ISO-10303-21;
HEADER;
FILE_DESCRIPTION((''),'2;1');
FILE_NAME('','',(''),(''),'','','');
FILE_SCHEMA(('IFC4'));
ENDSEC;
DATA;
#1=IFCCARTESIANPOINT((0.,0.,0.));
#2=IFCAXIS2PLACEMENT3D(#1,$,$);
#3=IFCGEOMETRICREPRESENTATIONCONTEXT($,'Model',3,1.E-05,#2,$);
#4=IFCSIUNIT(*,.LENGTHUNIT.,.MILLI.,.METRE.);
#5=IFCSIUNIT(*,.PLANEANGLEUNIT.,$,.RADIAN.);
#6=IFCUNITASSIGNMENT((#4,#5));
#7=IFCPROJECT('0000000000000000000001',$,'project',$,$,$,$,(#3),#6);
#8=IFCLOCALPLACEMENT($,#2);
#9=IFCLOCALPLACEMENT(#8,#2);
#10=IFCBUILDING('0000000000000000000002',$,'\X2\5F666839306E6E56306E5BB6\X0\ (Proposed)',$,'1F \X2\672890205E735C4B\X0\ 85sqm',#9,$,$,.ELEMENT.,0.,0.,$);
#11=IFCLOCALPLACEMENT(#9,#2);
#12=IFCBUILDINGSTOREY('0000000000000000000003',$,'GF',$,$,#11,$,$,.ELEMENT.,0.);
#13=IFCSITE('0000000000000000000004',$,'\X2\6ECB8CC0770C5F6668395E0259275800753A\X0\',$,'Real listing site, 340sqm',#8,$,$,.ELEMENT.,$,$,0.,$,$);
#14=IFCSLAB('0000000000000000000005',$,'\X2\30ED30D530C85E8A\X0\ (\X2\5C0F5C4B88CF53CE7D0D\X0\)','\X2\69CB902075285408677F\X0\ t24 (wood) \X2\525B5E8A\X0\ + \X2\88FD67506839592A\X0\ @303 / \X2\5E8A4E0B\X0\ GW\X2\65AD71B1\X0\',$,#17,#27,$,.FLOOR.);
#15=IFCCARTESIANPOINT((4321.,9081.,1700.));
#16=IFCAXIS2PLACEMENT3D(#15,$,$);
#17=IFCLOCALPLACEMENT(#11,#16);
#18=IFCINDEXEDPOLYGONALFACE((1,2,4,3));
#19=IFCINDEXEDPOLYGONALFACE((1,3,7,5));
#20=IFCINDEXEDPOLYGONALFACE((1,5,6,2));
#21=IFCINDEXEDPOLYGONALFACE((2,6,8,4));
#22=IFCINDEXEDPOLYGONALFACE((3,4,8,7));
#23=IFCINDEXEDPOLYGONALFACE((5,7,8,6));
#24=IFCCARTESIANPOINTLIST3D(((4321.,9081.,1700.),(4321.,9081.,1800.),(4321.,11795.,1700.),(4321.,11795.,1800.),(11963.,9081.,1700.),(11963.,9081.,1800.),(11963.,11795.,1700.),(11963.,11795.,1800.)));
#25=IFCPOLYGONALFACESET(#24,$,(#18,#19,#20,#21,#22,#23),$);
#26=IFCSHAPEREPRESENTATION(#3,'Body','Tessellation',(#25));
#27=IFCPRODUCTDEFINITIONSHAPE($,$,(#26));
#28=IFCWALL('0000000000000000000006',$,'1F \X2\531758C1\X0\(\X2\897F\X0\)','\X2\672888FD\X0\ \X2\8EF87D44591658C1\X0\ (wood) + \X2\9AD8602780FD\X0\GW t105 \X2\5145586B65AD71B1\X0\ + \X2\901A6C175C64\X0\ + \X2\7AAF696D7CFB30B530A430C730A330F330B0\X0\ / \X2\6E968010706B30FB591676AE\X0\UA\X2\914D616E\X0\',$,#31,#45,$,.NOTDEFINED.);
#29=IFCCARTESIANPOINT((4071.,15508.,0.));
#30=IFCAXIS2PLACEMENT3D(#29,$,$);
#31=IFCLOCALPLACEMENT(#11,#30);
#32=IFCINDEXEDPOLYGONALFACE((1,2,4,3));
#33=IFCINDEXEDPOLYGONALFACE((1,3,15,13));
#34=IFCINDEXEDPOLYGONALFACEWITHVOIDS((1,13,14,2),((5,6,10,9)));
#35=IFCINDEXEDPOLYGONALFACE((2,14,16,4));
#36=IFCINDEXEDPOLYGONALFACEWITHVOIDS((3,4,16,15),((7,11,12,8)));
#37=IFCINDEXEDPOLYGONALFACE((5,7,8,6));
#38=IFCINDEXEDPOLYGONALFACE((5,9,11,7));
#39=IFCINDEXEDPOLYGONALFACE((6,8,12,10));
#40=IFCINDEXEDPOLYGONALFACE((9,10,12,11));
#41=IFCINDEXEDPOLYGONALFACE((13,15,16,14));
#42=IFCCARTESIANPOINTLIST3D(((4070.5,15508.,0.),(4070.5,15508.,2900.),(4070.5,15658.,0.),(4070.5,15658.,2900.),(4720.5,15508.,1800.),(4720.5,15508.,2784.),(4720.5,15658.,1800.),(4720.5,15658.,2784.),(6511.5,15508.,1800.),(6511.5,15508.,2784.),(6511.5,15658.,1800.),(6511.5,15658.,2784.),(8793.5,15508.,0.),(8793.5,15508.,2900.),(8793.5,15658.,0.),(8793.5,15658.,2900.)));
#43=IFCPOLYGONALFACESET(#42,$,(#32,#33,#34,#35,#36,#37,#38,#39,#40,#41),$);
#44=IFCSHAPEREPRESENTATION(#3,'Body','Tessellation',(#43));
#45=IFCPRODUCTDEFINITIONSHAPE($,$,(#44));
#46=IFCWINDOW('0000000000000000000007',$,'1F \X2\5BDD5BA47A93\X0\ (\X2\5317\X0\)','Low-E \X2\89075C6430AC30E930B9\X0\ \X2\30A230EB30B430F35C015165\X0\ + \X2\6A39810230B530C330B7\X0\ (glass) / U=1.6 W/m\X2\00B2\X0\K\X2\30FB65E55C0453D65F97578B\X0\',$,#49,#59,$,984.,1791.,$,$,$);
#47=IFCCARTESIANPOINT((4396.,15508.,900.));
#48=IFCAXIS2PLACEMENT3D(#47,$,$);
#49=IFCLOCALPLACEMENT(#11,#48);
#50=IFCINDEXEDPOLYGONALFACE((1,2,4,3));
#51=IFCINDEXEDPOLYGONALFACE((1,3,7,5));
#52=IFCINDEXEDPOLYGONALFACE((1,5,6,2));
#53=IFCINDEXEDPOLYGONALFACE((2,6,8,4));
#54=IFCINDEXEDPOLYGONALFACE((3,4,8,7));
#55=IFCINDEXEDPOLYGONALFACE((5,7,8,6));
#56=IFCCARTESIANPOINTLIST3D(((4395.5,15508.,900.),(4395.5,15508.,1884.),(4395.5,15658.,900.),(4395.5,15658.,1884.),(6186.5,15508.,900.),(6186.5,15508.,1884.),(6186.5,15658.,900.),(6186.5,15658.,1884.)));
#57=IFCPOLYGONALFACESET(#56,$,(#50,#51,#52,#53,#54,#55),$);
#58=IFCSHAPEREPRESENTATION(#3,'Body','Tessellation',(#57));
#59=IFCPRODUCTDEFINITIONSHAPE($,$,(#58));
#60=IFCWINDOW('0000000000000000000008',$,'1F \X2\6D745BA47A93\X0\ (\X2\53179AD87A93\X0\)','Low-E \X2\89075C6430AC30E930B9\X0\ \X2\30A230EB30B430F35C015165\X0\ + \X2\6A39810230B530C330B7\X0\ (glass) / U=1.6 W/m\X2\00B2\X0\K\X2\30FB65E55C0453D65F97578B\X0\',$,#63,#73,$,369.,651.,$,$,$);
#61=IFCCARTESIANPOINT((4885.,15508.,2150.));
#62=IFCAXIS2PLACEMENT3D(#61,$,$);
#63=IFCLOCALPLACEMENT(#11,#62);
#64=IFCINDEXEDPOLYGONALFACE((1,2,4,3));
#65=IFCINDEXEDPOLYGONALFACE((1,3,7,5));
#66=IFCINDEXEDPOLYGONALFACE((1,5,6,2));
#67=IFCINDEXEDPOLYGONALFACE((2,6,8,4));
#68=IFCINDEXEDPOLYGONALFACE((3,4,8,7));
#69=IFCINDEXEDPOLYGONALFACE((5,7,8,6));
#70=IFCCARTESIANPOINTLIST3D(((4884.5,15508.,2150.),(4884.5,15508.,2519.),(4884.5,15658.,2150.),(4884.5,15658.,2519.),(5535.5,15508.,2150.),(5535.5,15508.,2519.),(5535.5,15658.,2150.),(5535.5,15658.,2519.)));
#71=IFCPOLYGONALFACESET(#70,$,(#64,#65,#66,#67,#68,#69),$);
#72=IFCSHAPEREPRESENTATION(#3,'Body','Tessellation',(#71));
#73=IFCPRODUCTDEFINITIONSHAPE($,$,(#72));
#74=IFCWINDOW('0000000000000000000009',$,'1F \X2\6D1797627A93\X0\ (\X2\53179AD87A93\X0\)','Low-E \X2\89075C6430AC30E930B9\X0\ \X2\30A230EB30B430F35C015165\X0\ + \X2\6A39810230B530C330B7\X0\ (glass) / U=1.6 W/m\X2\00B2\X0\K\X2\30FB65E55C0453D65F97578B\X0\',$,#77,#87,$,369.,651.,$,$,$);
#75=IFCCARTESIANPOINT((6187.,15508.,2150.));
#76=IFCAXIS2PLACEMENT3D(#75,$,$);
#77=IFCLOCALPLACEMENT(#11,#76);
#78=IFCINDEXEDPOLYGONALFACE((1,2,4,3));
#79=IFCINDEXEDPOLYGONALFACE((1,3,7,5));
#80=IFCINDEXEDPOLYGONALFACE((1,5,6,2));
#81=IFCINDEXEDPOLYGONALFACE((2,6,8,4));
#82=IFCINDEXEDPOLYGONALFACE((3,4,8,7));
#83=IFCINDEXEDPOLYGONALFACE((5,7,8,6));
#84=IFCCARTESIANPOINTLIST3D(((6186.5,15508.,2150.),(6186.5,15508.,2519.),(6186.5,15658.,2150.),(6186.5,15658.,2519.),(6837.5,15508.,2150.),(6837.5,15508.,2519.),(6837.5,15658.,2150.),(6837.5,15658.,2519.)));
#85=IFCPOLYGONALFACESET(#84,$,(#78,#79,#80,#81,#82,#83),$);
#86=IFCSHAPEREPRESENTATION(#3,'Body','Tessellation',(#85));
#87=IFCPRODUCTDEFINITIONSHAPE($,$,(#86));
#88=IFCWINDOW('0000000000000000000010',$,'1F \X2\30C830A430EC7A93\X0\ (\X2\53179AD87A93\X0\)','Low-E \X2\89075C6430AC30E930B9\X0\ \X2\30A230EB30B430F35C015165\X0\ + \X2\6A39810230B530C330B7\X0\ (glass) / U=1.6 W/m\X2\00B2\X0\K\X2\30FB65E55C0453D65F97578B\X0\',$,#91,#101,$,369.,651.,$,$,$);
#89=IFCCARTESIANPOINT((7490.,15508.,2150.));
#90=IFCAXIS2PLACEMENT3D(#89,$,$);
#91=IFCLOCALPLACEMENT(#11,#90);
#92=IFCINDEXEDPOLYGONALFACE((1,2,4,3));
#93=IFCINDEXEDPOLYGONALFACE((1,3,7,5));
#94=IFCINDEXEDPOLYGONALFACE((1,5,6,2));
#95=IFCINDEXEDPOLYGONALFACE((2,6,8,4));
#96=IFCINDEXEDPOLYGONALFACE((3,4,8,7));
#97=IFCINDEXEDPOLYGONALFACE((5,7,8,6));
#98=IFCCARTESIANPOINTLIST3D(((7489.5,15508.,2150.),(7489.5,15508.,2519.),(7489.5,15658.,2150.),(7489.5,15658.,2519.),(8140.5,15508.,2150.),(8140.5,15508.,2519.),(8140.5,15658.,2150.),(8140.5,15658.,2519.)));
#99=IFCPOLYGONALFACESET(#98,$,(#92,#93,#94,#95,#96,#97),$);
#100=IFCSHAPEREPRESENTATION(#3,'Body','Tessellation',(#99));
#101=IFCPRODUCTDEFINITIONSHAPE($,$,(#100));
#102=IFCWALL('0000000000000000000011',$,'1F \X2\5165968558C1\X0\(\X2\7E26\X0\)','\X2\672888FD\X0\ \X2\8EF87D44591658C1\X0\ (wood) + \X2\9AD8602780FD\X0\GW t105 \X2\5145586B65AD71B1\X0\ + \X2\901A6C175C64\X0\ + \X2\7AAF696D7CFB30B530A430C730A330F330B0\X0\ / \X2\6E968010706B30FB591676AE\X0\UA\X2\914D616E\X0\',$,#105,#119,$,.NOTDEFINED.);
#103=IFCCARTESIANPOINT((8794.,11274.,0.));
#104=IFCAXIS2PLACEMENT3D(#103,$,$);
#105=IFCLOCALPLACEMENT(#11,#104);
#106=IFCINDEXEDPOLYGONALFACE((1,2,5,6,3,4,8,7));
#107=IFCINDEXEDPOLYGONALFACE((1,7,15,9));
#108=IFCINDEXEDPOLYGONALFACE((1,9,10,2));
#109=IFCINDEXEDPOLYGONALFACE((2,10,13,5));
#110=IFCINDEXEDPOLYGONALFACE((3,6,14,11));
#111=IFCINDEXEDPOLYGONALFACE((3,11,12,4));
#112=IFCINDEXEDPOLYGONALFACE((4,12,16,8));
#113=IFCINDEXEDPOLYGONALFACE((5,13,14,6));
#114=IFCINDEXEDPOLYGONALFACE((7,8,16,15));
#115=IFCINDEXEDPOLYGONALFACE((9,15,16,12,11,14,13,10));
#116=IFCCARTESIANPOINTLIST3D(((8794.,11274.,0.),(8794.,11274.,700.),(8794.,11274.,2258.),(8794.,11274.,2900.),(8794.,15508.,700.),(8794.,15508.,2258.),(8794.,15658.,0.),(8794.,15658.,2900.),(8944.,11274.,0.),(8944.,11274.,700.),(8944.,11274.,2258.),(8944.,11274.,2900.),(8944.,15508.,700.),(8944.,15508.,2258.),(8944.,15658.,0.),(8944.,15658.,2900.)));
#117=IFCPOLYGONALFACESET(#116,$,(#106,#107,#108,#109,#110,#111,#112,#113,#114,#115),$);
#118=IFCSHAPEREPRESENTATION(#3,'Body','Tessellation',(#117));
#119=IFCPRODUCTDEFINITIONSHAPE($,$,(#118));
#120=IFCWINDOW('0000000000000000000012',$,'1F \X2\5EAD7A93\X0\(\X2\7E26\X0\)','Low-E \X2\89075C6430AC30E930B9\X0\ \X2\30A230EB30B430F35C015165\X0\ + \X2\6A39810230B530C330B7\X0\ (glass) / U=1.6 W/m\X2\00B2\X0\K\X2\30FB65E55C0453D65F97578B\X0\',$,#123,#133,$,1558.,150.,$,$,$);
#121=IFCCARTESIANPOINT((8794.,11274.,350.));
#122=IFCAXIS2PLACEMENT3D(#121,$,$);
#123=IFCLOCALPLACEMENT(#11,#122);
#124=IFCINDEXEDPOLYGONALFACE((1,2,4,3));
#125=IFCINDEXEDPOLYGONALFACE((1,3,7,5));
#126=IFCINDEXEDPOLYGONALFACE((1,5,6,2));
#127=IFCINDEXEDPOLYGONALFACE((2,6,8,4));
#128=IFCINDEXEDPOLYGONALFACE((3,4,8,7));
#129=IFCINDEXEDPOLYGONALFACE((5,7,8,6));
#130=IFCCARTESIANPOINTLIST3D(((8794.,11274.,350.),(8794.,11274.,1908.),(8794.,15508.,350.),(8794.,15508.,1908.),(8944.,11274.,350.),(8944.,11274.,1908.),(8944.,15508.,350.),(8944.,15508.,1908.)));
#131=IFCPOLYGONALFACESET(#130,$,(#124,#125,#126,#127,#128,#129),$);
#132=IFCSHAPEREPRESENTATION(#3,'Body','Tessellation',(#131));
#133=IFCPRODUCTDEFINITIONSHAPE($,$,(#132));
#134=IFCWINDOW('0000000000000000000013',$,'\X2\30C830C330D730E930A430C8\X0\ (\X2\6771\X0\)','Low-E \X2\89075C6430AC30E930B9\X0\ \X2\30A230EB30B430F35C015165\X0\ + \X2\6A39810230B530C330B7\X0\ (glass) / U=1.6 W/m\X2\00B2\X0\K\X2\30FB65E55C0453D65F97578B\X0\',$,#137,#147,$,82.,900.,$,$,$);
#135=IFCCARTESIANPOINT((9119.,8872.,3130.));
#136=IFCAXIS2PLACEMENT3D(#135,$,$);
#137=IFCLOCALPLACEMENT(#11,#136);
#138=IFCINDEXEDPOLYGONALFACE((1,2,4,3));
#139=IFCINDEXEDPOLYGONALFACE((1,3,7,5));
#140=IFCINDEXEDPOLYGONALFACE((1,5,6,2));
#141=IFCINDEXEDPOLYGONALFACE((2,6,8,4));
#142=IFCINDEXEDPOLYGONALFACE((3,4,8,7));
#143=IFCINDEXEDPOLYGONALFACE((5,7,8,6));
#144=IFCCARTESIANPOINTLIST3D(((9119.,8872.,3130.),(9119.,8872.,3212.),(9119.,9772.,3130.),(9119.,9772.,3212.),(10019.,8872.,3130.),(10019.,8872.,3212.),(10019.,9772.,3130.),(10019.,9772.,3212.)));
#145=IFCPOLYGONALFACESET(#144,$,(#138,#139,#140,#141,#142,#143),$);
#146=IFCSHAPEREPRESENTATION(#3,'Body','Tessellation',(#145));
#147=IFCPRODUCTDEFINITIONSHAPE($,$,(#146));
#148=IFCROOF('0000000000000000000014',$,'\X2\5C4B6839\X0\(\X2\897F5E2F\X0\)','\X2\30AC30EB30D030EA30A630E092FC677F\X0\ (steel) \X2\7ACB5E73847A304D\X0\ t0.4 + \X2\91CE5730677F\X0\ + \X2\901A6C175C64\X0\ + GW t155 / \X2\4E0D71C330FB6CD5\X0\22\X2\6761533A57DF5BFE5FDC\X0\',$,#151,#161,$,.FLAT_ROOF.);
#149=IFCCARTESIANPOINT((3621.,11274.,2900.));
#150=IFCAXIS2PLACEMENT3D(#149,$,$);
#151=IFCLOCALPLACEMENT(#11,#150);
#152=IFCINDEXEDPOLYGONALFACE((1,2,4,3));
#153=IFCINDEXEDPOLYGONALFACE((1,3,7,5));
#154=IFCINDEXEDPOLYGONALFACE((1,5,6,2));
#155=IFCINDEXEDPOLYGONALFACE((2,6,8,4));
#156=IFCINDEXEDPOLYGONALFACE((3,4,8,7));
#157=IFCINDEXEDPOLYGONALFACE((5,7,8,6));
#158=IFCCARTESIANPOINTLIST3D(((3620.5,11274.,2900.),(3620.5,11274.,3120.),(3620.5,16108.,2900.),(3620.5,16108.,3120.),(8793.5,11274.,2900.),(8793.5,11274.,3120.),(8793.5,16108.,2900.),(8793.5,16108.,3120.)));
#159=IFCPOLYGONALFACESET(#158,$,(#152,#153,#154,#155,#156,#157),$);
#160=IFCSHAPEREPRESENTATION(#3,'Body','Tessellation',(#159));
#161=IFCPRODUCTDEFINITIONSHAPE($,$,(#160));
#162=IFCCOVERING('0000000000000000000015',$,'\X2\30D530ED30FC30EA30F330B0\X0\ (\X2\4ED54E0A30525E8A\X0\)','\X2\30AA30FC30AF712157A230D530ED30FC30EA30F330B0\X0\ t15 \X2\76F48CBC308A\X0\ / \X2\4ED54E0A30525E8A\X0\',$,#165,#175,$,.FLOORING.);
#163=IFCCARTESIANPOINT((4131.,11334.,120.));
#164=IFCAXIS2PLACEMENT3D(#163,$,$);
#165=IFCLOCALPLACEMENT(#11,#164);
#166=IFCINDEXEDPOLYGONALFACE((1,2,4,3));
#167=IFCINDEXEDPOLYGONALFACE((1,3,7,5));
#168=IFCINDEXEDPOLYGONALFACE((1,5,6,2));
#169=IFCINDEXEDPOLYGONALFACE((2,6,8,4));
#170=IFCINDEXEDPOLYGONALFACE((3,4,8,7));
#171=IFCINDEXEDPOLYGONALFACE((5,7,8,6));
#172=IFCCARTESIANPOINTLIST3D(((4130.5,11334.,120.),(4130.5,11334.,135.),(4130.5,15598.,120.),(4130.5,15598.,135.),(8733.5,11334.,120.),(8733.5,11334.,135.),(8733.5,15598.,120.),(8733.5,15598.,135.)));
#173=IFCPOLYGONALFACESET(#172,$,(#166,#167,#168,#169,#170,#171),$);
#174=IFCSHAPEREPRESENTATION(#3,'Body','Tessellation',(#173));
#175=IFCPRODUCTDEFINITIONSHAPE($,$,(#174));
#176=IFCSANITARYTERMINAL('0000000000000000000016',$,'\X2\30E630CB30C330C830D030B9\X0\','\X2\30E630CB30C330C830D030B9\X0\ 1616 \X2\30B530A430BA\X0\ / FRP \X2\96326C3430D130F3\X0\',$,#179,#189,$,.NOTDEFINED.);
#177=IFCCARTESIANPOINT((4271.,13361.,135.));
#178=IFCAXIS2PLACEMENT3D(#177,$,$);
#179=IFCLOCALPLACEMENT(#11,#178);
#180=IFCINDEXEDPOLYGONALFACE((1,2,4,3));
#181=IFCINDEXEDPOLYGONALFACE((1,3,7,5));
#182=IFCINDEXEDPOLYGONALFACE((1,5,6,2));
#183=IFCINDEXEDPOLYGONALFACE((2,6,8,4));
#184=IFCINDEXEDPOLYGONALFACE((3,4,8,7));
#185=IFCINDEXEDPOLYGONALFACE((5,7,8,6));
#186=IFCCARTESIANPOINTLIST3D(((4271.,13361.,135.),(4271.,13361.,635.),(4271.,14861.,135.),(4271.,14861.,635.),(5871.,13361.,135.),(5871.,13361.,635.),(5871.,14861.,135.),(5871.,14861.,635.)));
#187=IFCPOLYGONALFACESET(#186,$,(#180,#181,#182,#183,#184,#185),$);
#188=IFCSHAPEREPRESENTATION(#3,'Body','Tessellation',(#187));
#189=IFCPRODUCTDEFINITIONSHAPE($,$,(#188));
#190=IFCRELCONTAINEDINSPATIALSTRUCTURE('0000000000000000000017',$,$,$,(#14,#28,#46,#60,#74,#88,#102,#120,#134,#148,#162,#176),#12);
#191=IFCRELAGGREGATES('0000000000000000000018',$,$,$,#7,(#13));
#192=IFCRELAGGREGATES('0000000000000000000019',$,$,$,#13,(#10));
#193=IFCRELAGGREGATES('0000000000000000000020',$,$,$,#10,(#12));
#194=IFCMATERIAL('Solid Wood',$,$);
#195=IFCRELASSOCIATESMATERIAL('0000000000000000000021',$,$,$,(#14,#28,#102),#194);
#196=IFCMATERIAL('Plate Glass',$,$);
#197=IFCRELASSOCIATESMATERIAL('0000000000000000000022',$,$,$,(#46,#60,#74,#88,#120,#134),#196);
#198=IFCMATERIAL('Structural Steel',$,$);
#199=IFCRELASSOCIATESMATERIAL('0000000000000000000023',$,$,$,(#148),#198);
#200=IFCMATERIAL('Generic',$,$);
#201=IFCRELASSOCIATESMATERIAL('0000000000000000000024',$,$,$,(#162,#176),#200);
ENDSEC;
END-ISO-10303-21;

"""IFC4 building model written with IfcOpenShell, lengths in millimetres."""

from ifc_helpers import new_model, si_unit, frame, frame_2d, origin, place, context, project, spatial, rectangle, extrude, material, element, fill, save


model = new_model("IFC4")

# Units and contexts
model_context = context("Model", 3, precision=1e-05, world=origin())
ifc_project = project(units=[si_unit("LENGTHUNIT", "METRE", prefix="MILLI"), si_unit("PLANEANGLEUNIT", "RADIAN")], contexts=[model_context])

# Site, building, storey
site_placement = place(None, origin())
site = spatial("IfcSite", under=ifc_project, at=site_placement, Name="滋賀県彦根市大堀町", ObjectType="Real listing site, 340sqm", CompositionType="ELEMENT", RefElevation=0.0)
building_placement = place(site_placement, origin())
building = spatial("IfcBuilding", under=site, at=building_placement, Name="彦根の湖の家 (Proposed)", ObjectType="1F 木造平屋 85sqm", CompositionType="ELEMENT", ElevationOfRefHeight=0.0, ElevationOfTerrain=0.0)
storey_placement = place(building_placement, origin())
storey = spatial("IfcBuildingStorey", under=building, at=storey_placement, Name="GF", CompositionType="ELEMENT", Elevation=0.0)

# Slab
ifc_material_1 = material(Name="Solid Wood")
slab_1_placement = place(storey_placement, frame((4321.0, 9081.0, 1700.0)))
element("IfcSlab", 1, at=slab_1_placement, inside=storey, material=ifc_material_1, Name="ロフト床 (小屋裏収納)", Description="構造用合板 t24 (wood) 剛床 + 製材根太 @303 / 床下 GW断熱", PredefinedType="FLOOR", context=model_context, shape_type="SweptSolid", body=[
    extrude(rectangle(XDim=7642.0, YDim=2714.0, at=frame_2d((3821.0, 1357.0))), frame((4321.0, 9081.0, 1700.0)), (0.0, 0.0, 1.0), 100.0),
])

# Wall, openings, windows
wall_1_placement = place(storey_placement, frame((4071.0, 15508.0, 0.0)))
wall_1 = element("IfcWall", 2, at=wall_1_placement, inside=storey, material=ifc_material_1, Name="1F 北壁(西)", Description="木製 軸組外壁 (wood) + 高性能GW t105 充填断熱 + 通気層 + 窯業系サイディング / 準耐火・外皮UA配慮", PredefinedType="NOTDEFINED", context=model_context, shape_type="SweptSolid", body=[
    extrude(rectangle(XDim=4723.0, YDim=150.0, at=frame_2d((2361.0, 75.0))), frame((4071.0, 15508.0, 0.0)), (0.0, 0.0, 1.0), 2900.0),
])
opening_1_placement = place(storey_placement, frame((4396.0, 15508.0, 900.0)))
opening_1 = element("IfcOpeningElement", 3, at=opening_1_placement, cuts=wall_1, PredefinedType="NOTDEFINED", context=model_context, shape_type="SweptSolid", body=[
    extrude(rectangle(XDim=1791.0, YDim=150.0, at=frame_2d((895.0, 75.0))), frame((4396.0, 15508.0, 900.0)), (0.0, 0.0, 1.0), 984.0),
])
opening_2_placement = place(storey_placement, frame((4885.0, 15508.0, 2150.0)))
opening_2 = element("IfcOpeningElement", 4, at=opening_2_placement, cuts=wall_1, PredefinedType="NOTDEFINED", context=model_context, shape_type="SweptSolid", body=[
    extrude(rectangle(XDim=651.0, YDim=150.0, at=frame_2d((325.0, 75.0))), frame((4885.0, 15508.0, 2150.0)), (0.0, 0.0, 1.0), 369.0),
])
opening_3_placement = place(storey_placement, frame((6187.0, 15508.0, 2150.0)))
opening_3 = element("IfcOpeningElement", 5, at=opening_3_placement, cuts=wall_1, PredefinedType="NOTDEFINED", context=model_context, shape_type="SweptSolid", body=[
    extrude(rectangle(XDim=651.0, YDim=150.0, at=frame_2d((325.0, 75.0))), frame((6187.0, 15508.0, 2150.0)), (0.0, 0.0, 1.0), 369.0),
])
opening_4_placement = place(storey_placement, frame((7490.0, 15508.0, 2150.0)))
opening_4 = element("IfcOpeningElement", 6, at=opening_4_placement, cuts=wall_1, PredefinedType="NOTDEFINED", context=model_context, shape_type="SweptSolid", body=[
    extrude(rectangle(XDim=651.0, YDim=150.0, at=frame_2d((325.0, 75.0))), frame((7490.0, 15508.0, 2150.0)), (0.0, 0.0, 1.0), 369.0),
])
ifc_material_2 = material(Name="Plate Glass")
window_1_placement = place(storey_placement, frame((4396.0, 15508.0, 900.0)))
window_1 = element("IfcWindow", 7, at=window_1_placement, inside=storey, material=ifc_material_2, Name="1F 寝室窓 (北)", Description="Low-E 複層ガラス アルゴン封入 + 樹脂サッシ (glass) / U=1.6 W/m²K・日射取得型", OverallHeight=984.0, OverallWidth=1791.0, context=model_context, shape_type="SweptSolid", body=[
    extrude(rectangle(XDim=1791.0, YDim=150.0, at=frame_2d((895.0, 75.0))), frame((4396.0, 15508.0, 900.0)), (0.0, 0.0, 1.0), 984.0),
])
fill(opening_1, window_1)
window_2_placement = place(storey_placement, frame((4885.0, 15508.0, 2150.0)))
window_2 = element("IfcWindow", 8, at=window_2_placement, inside=storey, material=ifc_material_2, Name="1F 浴室窓 (北高窓)", Description="Low-E 複層ガラス アルゴン封入 + 樹脂サッシ (glass) / U=1.6 W/m²K・日射取得型", OverallHeight=369.0, OverallWidth=651.0, context=model_context, shape_type="SweptSolid", body=[
    extrude(rectangle(XDim=651.0, YDim=150.0, at=frame_2d((325.0, 75.0))), frame((4885.0, 15508.0, 2150.0)), (0.0, 0.0, 1.0), 369.0),
])
fill(opening_2, window_2)
window_3_placement = place(storey_placement, frame((6187.0, 15508.0, 2150.0)))
window_3 = element("IfcWindow", 9, at=window_3_placement, inside=storey, material=ifc_material_2, Name="1F 洗面窓 (北高窓)", Description="Low-E 複層ガラス アルゴン封入 + 樹脂サッシ (glass) / U=1.6 W/m²K・日射取得型", OverallHeight=369.0, OverallWidth=651.0, context=model_context, shape_type="SweptSolid", body=[
    extrude(rectangle(XDim=651.0, YDim=150.0, at=frame_2d((325.0, 75.0))), frame((6187.0, 15508.0, 2150.0)), (0.0, 0.0, 1.0), 369.0),
])
fill(opening_3, window_3)
window_4_placement = place(storey_placement, frame((7490.0, 15508.0, 2150.0)))
window_4 = element("IfcWindow", 10, at=window_4_placement, inside=storey, material=ifc_material_2, Name="1F トイレ窓 (北高窓)", Description="Low-E 複層ガラス アルゴン封入 + 樹脂サッシ (glass) / U=1.6 W/m²K・日射取得型", OverallHeight=369.0, OverallWidth=651.0, context=model_context, shape_type="SweptSolid", body=[
    extrude(rectangle(XDim=651.0, YDim=150.0, at=frame_2d((325.0, 75.0))), frame((7490.0, 15508.0, 2150.0)), (0.0, 0.0, 1.0), 369.0),
])
fill(opening_4, window_4)

# Wall, opening, window
wall_2_placement = place(storey_placement, frame((8794.0, 11274.0, 0.0)))
wall_2 = element("IfcWall", 11, at=wall_2_placement, inside=storey, material=ifc_material_1, Name="1F 入隅壁(縦)", Description="木製 軸組外壁 (wood) + 高性能GW t105 充填断熱 + 通気層 + 窯業系サイディング / 準耐火・外皮UA配慮", PredefinedType="NOTDEFINED", context=model_context, shape_type="SweptSolid", body=[
    extrude(rectangle(XDim=150.0, YDim=4384.0, at=frame_2d((75.0, 2192.0))), frame((8794.0, 11274.0, 0.0)), (0.0, 0.0, 1.0), 2900.0),
])
opening_5_placement = place(storey_placement, frame((8794.0, 11274.0, 350.0)))
opening_5 = element("IfcOpeningElement", 12, at=opening_5_placement, cuts=wall_2, PredefinedType="NOTDEFINED", context=model_context, shape_type="SweptSolid", body=[
    extrude(rectangle(XDim=150.0, YDim=4234.0, at=frame_2d((75.0, 2117.0))), frame((8794.0, 11274.0, 350.0)), (0.0, 0.0, 1.0), 1558.0),
])
window_5_placement = place(storey_placement, frame((8794.0, 11274.0, 350.0)))
window_5 = element("IfcWindow", 13, at=window_5_placement, inside=storey, material=ifc_material_2, Name="1F 庭窓(縦)", Description="Low-E 複層ガラス アルゴン封入 + 樹脂サッシ (glass) / U=1.6 W/m²K・日射取得型", OverallHeight=1558.0, OverallWidth=150.0, context=model_context, shape_type="SweptSolid", body=[
    extrude(rectangle(XDim=150.0, YDim=4234.0, at=frame_2d((75.0, 2117.0))), frame((8794.0, 11274.0, 350.0)), (0.0, 0.0, 1.0), 1558.0),
])
fill(opening_5, window_5)

# Window
window_6_placement = place(storey_placement, frame((9119.0, 8872.0, 3130.0)))
element("IfcWindow", 14, at=window_6_placement, inside=storey, material=ifc_material_2, Name="トップライト (東)", Description="Low-E 複層ガラス アルゴン封入 + 樹脂サッシ (glass) / U=1.6 W/m²K・日射取得型", OverallHeight=82.0, OverallWidth=900.0, context=model_context, shape_type="SweptSolid", body=[
    extrude(rectangle(XDim=900.0, YDim=900.0, at=frame_2d((450.0, 450.0))), frame((9119.0, 8872.0, 3130.0)), (0.0, 0.0, 1.0), 82.0),
])

# Roof
ifc_material_3 = material(Name="Structural Steel")
roof_placement = place(storey_placement, frame((3621.0, 11274.0, 2900.0)))
element("IfcRoof", 15, at=roof_placement, inside=storey, material=ifc_material_3, Name="屋根(西帯)", Description="ガルバリウム鋼板 (steel) 立平葺き t0.4 + 野地板 + 通気層 + GW t155 / 不燃・法22条区域対応", PredefinedType="FLAT_ROOF", context=model_context, shape_type="SweptSolid", body=[
    extrude(rectangle(XDim=5173.0, YDim=4834.0, at=frame_2d((2586.0, 2417.0))), frame((3621.0, 11274.0, 2900.0)), (0.0, 0.0, 1.0), 220.0),
])

# Covering
ifc_material_4 = material(Name="Generic")
covering_placement = place(storey_placement, frame((4131.0, 11334.0, 120.0)))
element("IfcCovering", 16, at=covering_placement, inside=storey, material=ifc_material_4, Name="フローリング (仕上げ床)", Description="オーク無垢フローリング t15 直貼り / 仕上げ床", PredefinedType="FLOORING", context=model_context, shape_type="SweptSolid", body=[
    extrude(rectangle(XDim=4603.0, YDim=4264.0, at=frame_2d((2301.0, 2132.0))), frame((4131.0, 11334.0, 120.0)), (0.0, 0.0, 1.0), 15.0),
])

# Sanitary terminal
sanitary_terminal_1_placement = place(storey_placement, frame((4271.0, 13361.0, 135.0)))
element("IfcSanitaryTerminal", 17, at=sanitary_terminal_1_placement, inside=storey, material=ifc_material_4, Name="ユニットバス", Description="ユニットバス 1616 サイズ / FRP 防水パン", PredefinedType="NOTDEFINED", context=model_context, shape_type="SweptSolid", body=[
    extrude(rectangle(XDim=1600.0, YDim=1500.0, at=frame_2d((800.0, 750.0))), frame((4271.0, 13361.0, 135.0)), (0.0, 0.0, 1.0), 500.0),
])

save(model, "model.ifc")
